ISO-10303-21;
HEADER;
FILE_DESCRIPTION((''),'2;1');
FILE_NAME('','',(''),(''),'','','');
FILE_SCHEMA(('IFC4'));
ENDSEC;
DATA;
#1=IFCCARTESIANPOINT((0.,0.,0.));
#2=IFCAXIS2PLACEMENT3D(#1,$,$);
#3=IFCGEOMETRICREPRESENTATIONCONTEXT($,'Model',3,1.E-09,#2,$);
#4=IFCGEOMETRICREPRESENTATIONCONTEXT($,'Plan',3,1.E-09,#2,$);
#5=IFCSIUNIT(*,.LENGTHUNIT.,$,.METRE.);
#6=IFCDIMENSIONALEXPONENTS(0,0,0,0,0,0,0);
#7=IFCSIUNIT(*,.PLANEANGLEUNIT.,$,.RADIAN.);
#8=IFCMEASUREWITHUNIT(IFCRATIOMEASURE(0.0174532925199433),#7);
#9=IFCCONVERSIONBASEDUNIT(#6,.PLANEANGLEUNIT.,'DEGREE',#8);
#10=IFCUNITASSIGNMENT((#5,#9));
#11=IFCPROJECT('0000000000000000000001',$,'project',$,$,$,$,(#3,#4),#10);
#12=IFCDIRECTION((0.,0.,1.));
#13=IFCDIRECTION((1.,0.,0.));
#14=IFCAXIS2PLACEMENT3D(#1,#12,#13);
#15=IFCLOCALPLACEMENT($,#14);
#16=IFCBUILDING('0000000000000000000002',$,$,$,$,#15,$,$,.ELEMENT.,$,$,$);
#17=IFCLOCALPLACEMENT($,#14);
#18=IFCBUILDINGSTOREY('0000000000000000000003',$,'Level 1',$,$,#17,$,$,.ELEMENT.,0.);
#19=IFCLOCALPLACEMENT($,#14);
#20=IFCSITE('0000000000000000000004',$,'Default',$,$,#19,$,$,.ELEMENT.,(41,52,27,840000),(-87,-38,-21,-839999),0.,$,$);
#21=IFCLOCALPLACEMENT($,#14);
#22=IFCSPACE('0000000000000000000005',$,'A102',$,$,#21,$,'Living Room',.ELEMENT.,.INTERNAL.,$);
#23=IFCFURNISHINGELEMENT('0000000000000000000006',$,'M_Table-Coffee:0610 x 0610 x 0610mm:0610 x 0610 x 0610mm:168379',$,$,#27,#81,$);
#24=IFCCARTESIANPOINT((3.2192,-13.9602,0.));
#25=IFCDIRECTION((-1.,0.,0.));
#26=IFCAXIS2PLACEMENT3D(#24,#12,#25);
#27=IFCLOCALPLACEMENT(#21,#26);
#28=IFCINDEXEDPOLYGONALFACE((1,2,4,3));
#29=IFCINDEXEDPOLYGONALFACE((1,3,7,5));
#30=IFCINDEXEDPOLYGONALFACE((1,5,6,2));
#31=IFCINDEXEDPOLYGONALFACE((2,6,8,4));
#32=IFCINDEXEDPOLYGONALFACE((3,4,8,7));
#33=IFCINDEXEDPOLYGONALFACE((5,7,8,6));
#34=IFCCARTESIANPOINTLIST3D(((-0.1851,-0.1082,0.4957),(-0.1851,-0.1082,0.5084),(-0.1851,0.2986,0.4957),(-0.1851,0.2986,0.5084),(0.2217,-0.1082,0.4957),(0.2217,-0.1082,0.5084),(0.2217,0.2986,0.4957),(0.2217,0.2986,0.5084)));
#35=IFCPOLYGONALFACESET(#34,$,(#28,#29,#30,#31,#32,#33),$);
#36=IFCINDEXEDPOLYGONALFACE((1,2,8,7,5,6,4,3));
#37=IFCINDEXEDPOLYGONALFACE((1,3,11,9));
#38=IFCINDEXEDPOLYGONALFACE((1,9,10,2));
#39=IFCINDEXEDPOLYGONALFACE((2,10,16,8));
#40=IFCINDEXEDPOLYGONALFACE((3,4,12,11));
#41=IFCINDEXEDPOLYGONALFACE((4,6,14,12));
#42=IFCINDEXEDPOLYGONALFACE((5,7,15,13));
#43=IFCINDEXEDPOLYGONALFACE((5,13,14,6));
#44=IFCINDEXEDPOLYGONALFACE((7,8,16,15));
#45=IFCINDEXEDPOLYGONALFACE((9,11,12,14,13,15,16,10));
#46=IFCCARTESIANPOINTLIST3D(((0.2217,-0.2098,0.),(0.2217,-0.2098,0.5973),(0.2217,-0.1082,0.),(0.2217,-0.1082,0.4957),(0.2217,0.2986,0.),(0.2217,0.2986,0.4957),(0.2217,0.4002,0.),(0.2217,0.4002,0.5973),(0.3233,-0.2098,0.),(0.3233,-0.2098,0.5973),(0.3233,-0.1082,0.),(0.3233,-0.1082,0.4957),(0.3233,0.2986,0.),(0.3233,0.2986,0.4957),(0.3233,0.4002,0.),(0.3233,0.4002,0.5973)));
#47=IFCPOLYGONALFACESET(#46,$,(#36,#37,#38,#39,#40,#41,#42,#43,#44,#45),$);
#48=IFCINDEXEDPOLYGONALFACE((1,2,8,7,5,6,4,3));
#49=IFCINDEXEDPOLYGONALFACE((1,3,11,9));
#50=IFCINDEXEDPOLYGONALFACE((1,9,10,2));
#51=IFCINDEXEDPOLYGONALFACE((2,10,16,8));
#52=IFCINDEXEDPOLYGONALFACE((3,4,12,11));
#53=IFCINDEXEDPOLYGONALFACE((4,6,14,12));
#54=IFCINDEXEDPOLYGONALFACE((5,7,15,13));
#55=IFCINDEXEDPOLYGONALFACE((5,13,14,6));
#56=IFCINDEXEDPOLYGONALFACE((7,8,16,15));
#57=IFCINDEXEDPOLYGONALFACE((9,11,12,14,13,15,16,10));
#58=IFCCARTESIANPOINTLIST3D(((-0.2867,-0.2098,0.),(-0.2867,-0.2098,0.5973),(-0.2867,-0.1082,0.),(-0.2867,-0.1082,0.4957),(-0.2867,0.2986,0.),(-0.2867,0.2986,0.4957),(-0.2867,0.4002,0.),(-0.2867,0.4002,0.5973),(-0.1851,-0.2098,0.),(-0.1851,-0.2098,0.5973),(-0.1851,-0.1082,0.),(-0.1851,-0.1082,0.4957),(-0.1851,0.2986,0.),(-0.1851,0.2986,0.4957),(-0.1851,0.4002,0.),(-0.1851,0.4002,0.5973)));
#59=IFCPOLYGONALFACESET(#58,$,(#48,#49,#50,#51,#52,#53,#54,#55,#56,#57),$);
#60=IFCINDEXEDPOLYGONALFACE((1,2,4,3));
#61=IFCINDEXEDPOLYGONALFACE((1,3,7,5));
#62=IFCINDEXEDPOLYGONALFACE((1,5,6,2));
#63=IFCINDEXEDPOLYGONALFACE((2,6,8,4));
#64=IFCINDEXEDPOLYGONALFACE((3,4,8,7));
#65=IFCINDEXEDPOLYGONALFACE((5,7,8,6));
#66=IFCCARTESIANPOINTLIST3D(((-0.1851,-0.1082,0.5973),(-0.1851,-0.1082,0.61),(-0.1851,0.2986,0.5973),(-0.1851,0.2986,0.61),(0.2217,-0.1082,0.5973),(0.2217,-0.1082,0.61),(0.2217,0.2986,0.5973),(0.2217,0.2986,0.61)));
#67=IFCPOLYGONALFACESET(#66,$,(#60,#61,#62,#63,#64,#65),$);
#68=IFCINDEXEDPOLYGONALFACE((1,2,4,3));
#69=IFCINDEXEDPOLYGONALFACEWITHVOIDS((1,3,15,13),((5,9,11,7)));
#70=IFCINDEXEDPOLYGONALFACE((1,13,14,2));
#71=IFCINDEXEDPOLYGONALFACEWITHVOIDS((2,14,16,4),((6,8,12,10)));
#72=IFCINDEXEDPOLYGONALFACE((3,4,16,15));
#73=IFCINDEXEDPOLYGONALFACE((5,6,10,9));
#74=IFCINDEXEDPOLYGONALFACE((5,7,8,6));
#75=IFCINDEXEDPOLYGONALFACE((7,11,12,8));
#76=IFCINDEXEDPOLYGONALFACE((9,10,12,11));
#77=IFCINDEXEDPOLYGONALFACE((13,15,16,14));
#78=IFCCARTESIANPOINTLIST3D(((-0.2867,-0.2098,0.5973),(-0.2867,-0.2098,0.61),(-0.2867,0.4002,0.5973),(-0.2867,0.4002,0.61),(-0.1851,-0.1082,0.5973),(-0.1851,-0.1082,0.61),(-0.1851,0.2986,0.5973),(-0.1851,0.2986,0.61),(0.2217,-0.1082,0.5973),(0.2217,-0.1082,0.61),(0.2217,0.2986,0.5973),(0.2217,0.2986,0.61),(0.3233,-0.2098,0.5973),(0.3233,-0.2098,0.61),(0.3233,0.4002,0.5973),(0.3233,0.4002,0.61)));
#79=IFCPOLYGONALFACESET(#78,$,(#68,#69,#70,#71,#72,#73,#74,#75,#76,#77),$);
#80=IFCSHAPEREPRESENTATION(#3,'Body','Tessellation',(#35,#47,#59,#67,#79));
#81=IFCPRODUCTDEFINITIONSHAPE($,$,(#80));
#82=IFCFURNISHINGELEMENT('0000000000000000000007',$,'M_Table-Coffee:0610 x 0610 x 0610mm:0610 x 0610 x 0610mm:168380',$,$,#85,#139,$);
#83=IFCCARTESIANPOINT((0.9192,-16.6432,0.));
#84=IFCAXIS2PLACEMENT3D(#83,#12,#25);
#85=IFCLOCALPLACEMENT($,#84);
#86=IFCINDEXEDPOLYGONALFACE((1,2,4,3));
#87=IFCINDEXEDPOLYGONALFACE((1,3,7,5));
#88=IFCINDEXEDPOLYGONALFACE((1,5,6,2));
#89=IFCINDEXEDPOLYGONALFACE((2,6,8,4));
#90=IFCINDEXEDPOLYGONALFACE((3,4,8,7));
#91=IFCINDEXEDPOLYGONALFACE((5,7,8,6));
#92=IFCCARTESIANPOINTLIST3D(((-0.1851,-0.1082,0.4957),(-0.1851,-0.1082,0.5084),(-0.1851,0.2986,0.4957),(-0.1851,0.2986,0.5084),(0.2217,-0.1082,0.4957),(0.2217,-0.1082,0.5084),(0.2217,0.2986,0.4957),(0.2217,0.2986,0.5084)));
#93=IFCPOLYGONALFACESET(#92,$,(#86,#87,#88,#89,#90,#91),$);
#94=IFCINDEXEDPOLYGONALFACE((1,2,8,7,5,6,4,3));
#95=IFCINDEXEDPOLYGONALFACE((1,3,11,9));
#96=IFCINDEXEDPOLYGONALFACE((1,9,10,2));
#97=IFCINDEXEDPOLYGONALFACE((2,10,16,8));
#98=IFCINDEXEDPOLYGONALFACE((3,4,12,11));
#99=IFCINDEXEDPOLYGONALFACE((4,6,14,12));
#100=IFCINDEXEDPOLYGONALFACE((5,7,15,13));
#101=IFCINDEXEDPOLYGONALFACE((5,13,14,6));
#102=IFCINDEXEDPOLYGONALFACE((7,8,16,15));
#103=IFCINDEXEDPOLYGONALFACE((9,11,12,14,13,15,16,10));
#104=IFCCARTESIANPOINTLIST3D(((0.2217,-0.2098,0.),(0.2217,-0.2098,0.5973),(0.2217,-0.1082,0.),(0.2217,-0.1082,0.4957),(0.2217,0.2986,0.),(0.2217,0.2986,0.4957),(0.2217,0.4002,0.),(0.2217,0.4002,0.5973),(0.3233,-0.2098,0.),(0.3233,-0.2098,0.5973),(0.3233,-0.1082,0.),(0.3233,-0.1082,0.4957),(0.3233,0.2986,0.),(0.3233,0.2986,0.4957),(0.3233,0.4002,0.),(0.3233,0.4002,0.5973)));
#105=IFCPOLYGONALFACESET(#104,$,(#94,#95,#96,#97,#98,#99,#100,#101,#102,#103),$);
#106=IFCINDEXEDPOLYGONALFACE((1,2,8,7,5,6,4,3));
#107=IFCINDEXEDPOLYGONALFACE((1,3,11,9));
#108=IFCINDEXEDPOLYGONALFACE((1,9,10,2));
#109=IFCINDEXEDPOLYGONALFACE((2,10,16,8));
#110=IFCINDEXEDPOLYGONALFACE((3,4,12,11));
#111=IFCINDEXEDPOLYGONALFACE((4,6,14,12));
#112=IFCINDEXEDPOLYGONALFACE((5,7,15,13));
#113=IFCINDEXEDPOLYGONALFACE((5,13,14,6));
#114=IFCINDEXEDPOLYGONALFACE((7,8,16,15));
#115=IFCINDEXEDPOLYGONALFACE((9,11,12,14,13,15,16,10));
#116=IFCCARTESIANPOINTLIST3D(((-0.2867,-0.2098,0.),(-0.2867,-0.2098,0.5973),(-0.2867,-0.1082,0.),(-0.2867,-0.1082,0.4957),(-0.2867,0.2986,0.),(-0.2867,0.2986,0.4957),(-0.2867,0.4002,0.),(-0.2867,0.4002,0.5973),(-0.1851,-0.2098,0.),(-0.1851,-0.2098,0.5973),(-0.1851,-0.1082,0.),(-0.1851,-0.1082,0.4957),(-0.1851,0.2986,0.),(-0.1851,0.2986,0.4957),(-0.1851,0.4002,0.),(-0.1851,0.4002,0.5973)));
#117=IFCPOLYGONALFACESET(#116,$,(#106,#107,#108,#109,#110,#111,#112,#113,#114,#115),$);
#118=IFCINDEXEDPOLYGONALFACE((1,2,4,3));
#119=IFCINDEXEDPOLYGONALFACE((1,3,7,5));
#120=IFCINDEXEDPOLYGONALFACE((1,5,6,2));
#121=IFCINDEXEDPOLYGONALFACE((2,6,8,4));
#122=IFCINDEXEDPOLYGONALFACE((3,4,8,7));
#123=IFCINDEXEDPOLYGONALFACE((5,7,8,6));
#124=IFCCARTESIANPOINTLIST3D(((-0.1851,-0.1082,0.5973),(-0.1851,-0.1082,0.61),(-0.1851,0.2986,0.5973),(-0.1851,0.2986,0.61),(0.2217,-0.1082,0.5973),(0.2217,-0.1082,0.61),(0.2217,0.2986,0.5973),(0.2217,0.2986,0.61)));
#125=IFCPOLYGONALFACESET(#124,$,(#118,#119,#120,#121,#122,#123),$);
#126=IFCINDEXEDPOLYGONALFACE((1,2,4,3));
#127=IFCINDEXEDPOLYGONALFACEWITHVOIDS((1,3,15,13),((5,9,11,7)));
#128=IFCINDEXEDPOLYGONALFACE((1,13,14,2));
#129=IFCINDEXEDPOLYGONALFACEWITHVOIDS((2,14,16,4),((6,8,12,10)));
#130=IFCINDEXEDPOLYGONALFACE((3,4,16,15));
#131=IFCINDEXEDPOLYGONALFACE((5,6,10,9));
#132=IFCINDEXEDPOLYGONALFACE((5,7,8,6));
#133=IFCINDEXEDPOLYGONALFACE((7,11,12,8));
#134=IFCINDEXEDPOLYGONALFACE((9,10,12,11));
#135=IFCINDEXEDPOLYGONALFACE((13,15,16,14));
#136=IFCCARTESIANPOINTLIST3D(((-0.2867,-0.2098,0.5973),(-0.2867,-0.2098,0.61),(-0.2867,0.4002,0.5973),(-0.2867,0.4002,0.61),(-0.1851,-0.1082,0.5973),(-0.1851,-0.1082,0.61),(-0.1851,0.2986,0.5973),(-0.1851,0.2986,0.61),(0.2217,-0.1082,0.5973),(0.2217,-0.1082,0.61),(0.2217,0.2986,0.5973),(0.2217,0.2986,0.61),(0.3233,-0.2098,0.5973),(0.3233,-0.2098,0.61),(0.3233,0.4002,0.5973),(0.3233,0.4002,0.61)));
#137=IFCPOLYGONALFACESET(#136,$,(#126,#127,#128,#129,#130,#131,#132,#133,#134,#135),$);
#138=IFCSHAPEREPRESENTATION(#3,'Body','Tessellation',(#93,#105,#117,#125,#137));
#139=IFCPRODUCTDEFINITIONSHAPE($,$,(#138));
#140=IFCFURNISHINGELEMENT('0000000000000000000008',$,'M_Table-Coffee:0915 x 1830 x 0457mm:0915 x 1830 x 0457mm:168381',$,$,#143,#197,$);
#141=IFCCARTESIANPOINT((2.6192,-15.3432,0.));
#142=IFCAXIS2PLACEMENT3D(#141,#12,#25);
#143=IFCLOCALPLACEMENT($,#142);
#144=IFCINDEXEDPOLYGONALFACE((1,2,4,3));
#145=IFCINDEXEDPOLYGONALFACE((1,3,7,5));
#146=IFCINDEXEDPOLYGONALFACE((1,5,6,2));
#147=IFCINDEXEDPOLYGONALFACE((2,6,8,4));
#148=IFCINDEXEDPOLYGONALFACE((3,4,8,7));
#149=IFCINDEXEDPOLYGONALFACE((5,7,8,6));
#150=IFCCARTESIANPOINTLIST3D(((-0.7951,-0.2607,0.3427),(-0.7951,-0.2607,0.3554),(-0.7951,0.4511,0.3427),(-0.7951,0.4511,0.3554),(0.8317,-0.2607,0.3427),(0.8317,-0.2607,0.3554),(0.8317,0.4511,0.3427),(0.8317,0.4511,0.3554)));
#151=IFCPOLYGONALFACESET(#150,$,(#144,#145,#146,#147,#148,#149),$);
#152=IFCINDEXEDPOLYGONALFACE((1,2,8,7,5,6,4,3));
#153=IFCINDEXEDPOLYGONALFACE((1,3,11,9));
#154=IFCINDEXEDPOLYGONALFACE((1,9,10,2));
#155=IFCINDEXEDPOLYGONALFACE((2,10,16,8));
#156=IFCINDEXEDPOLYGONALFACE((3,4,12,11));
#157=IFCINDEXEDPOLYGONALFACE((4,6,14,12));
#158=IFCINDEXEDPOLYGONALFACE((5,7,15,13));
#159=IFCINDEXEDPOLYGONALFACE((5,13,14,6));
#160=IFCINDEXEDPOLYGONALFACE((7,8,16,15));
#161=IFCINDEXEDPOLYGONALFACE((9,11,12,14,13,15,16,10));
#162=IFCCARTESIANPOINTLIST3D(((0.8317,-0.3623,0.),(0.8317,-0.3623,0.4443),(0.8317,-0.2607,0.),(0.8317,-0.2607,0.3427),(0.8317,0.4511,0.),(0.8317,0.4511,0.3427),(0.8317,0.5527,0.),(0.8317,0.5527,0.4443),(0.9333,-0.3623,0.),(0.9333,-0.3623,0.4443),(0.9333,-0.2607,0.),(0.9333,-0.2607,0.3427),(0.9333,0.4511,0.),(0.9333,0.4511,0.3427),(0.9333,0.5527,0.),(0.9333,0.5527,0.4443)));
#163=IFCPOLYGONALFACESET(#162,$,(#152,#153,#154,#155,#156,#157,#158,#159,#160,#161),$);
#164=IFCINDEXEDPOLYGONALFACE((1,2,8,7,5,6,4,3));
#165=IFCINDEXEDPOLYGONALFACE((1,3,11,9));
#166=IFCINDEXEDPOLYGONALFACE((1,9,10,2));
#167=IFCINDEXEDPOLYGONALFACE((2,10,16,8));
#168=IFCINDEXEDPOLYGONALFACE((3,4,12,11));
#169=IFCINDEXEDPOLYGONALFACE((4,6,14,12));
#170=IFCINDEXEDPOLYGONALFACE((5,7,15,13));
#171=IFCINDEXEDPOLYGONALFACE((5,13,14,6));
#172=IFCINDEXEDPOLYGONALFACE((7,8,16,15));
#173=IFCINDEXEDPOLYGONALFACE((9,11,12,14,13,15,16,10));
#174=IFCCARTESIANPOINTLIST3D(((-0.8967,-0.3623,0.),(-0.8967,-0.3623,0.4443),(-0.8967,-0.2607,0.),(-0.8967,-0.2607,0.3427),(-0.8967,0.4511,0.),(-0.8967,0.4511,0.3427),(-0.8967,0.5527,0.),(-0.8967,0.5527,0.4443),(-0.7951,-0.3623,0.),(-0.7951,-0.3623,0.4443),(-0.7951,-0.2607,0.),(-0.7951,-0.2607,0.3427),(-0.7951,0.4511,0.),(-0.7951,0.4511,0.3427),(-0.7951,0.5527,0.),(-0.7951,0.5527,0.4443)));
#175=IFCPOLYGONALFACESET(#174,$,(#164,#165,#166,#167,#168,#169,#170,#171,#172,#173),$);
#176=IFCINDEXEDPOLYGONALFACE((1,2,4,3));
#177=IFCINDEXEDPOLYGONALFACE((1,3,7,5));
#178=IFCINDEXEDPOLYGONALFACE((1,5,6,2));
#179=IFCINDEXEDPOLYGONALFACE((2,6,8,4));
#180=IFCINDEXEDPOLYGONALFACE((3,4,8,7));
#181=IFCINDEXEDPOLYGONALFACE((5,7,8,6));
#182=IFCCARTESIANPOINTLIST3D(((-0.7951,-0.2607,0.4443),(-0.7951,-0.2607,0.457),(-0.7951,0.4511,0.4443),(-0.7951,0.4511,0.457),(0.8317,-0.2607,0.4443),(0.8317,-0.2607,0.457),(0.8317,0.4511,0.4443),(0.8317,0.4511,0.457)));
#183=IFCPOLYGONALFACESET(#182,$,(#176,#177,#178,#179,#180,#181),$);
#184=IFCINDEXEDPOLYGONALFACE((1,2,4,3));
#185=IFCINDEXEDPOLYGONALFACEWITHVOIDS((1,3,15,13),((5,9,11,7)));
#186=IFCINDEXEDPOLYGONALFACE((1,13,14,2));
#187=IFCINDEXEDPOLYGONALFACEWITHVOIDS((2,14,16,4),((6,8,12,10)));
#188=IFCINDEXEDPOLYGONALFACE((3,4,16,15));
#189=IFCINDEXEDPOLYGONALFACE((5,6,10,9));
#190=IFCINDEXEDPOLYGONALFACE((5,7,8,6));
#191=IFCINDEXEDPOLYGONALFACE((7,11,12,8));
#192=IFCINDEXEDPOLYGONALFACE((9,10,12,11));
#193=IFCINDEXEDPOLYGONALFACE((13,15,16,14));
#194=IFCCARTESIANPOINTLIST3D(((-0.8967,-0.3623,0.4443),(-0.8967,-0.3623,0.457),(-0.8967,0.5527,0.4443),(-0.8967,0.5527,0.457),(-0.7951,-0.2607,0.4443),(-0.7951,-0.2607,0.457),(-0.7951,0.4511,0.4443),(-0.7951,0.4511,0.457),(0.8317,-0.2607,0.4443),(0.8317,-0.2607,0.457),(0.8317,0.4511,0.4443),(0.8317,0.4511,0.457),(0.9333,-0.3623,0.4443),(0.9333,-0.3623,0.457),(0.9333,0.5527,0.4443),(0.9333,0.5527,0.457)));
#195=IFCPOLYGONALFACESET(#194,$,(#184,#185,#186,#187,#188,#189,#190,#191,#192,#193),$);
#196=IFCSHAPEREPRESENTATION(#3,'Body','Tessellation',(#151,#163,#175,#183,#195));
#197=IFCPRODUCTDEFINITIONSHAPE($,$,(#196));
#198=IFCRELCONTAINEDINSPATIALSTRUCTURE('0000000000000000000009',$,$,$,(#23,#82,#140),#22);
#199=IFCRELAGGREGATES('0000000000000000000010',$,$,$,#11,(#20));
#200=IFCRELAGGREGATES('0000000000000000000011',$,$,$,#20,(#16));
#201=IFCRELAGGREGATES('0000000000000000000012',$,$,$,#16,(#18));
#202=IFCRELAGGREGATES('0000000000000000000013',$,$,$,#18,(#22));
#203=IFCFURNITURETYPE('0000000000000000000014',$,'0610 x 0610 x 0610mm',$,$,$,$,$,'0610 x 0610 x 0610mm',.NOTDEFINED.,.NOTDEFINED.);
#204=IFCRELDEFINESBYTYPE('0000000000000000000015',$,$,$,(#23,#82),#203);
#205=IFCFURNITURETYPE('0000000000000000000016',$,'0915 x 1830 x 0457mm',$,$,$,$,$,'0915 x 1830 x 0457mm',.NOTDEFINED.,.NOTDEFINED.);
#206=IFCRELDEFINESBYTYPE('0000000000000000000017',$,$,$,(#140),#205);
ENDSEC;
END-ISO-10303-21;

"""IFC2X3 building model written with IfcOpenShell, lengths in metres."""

from ifc_helpers import new_model, entity, si_unit, converted_unit, frame, origin, origin_with_axes, origin_2d_with_axis, place, context, project, spatial, polyline, rectangle, outline, extrude, source, transform, mapped, type_object, type_shapes, element, save


model = new_model("IFC2X3")

# Units and contexts
model_context = context("Model", 3, precision=1e-09, world=origin())
plan_context = context("Plan", 3, precision=1e-09, world=origin())
ifc_project = project(units=[si_unit("LENGTHUNIT", "METRE"), converted_unit("PLANEANGLEUNIT", "DEGREE", entity("IfcRatioMeasure", 0.0174532925199433), si_unit("PLANEANGLEUNIT", "RADIAN"), dimensions=[0, 0, 0, 0, 0, 0, 0])], contexts=[model_context, plan_context])

# Site, building, storey, space
site_placement = place(None, origin_with_axes())
site = spatial("IfcSite", under=ifc_project, at=site_placement, Name="Default", CompositionType="ELEMENT", RefLatitude=(41, 52, 27, 840000), RefLongitude=(-87, -38, -21, -839999), RefElevation=0.0)
building_placement = place(None, origin_with_axes())
building = spatial("IfcBuilding", under=site, at=building_placement, CompositionType="ELEMENT")
storey_placement = place(None, origin_with_axes())
storey = spatial("IfcBuildingStorey", under=building, at=storey_placement, Name="Level 1", CompositionType="ELEMENT", Elevation=0.0)
space_placement = place(None, origin_with_axes())
space = spatial("IfcSpace", under=storey, at=space_placement, Name="A102", LongName="Living Room", CompositionType="ELEMENT", InteriorOrExteriorSpace="INTERNAL")

# Furnishing elements
furniture_type_1 = type_object("IfcFurnitureType", Name="0610 x 0610 x 0610mm", ElementType="0610 x 0610 x 0610mm", AssemblyPlace="NOTDEFINED")
shared_shape_1 = source(origin(), model_context, "Body", "SweptSolid", [
    extrude(rectangle(XDim=0.4068, YDim=0.4068, at=origin_2d_with_axis()), frame((0.0183, 0.0952, 0.4957), z_axis=(0.0, 0.0, 1.0), x_axis=(-1.0, 0.0, 0.0)), (0.0, 0.0, 1.0), 0.0127),
    extrude(outline(polyline([(-0.2732, -0.305), (0.324, -0.305), (0.324, 0.305), (-0.2732, 0.305), (-0.2732, 0.2034), (0.2225, 0.2034), (0.2225, -0.2034), (-0.2732, -0.2034), (-0.2732, -0.305)])), frame((0.2217, 0.0952, 0.2732), z_axis=(1.0, 0.0, 0.0), x_axis=(0.0, 0.0, 1.0)), (0.0, 0.0, 1.0), 0.1016),
    extrude(outline(polyline([(-0.305, -0.3241), (0.305, -0.3241), (0.305, 0.2733), (0.2034, 0.2733), (0.2034, -0.2224), (-0.2034, -0.2224), (-0.2034, 0.2733), (-0.305, 0.2733), (-0.305, -0.3241)])), frame((-0.2867, 0.0952, 0.2733), z_axis=(1.0, 0.0, 0.0), x_axis=(0.0, -1.0, 0.0)), (0.0, 0.0, 1.0), 0.1016),
    extrude(rectangle(XDim=0.4068, YDim=0.4068, at=origin_2d_with_axis()), frame((0.0183, 0.0952, 0.5973), z_axis=(0.0, 0.0, 1.0), x_axis=(-1.0, 0.0, 0.0)), (0.0, 0.0, 1.0), 0.0127),
    extrude(outline(polyline([(-0.305, -0.305), (0.305, -0.305), (0.305, 0.305), (-0.305, 0.305), (-0.305, -0.305)]), holes=[polyline([(-0.2034, -0.2034), (-0.2034, 0.2034), (0.2034, 0.2034), (0.2034, -0.2034), (-0.2034, -0.2034)])]), frame((0.0183, 0.0952, 0.5973), z_axis=(0.0, 0.0, 1.0), x_axis=(-1.0, 0.0, 0.0)), (0.0, 0.0, 1.0), 0.0127),
])
type_shapes(furniture_type_1, [shared_shape_1])
furnishing_1_placement = place(space_placement, frame((3.2192, -13.9602, 0.0), z_axis=(0.0, 0.0, 1.0), x_axis=(-1.0, 0.0, 0.0)))
element("IfcFurnishingElement", 1, at=furnishing_1_placement, inside=space, type_object=furniture_type_1, Name="M_Table-Coffee:0610 x 0610 x 0610mm:0610 x 0610 x 0610mm:168379", context=model_context, shape_type="MappedRepresentation", body=[
    mapped(shared_shape_1, transform((0.0, 0.0, 0.0), scale=1.0)),
])
furnishing_2_placement = place(None, frame((0.9192, -16.6432, 0.0), z_axis=(0.0, 0.0, 1.0), x_axis=(-1.0, 0.0, 0.0)))
element("IfcFurnishingElement", 2, at=furnishing_2_placement, inside=space, type_object=furniture_type_1, Name="M_Table-Coffee:0610 x 0610 x 0610mm:0610 x 0610 x 0610mm:168380", context=model_context, shape_type="MappedRepresentation", body=[
    mapped(shared_shape_1, transform((0.0, 0.0, 0.0), scale=1.0)),
])
furniture_type_2 = type_object("IfcFurnitureType", Name="0915 x 1830 x 0457mm", ElementType="0915 x 1830 x 0457mm", AssemblyPlace="NOTDEFINED")
shared_shape_2 = source(origin(), model_context, "Body", "SweptSolid", [
    extrude(rectangle(XDim=1.6268, YDim=0.7118, at=origin_2d_with_axis()), frame((0.0183, 0.0952, 0.3427), z_axis=(0.0, 0.0, 1.0), x_axis=(-1.0, 0.0, 0.0)), (0.0, 0.0, 1.0), 0.0127),
    extrude(outline(polyline([(-0.1967, -0.4575), (0.2475, -0.4575), (0.2475, 0.4575), (-0.1967, 0.4575), (-0.1967, 0.3559), (0.146, 0.3559), (0.146, -0.3559), (-0.1967, -0.3559), (-0.1967, -0.4575)])), frame((0.8317, 0.0952, 0.1967), z_axis=(1.0, 0.0, 0.0), x_axis=(0.0, 0.0, 1.0)), (0.0, 0.0, 1.0), 0.1016),
    extrude(outline(polyline([(-0.4575, -0.2476), (0.4575, -0.2476), (0.4575, 0.1968), (0.3559, 0.1968), (0.3559, -0.1459), (-0.3559, -0.1459), (-0.3559, 0.1968), (-0.4575, 0.1968), (-0.4575, -0.2476)])), frame((-0.8967, 0.0952, 0.1968), z_axis=(1.0, 0.0, 0.0), x_axis=(0.0, -1.0, 0.0)), (0.0, 0.0, 1.0), 0.1016),
    extrude(rectangle(XDim=1.6268, YDim=0.7118, at=origin_2d_with_axis()), frame((0.0183, 0.0952, 0.4443), z_axis=(0.0, 0.0, 1.0), x_axis=(-1.0, 0.0, 0.0)), (0.0, 0.0, 1.0), 0.0127),
    extrude(outline(polyline([(-0.915, -0.4575), (0.915, -0.4575), (0.915, 0.4575), (-0.915, 0.4575), (-0.915, -0.4575)]), holes=[polyline([(-0.8134, -0.3559), (-0.8134, 0.3559), (0.8134, 0.3559), (0.8134, -0.3559), (-0.8134, -0.3559)])]), frame((0.0183, 0.0952, 0.4443), z_axis=(0.0, 0.0, 1.0), x_axis=(-1.0, 0.0, 0.0)), (0.0, 0.0, 1.0), 0.0127),
])
type_shapes(furniture_type_2, [shared_shape_2])
furnishing_3_placement = place(None, frame((2.6192, -15.3432, 0.0), z_axis=(0.0, 0.0, 1.0), x_axis=(-1.0, 0.0, 0.0)))
element("IfcFurnishingElement", 3, at=furnishing_3_placement, inside=space, type_object=furniture_type_2, Name="M_Table-Coffee:0915 x 1830 x 0457mm:0915 x 1830 x 0457mm:168381", context=model_context, shape_type="MappedRepresentation", body=[
    mapped(shared_shape_2, transform((0.0, 0.0, 0.0), scale=1.0)),
])

save(model, "model.ifc")
